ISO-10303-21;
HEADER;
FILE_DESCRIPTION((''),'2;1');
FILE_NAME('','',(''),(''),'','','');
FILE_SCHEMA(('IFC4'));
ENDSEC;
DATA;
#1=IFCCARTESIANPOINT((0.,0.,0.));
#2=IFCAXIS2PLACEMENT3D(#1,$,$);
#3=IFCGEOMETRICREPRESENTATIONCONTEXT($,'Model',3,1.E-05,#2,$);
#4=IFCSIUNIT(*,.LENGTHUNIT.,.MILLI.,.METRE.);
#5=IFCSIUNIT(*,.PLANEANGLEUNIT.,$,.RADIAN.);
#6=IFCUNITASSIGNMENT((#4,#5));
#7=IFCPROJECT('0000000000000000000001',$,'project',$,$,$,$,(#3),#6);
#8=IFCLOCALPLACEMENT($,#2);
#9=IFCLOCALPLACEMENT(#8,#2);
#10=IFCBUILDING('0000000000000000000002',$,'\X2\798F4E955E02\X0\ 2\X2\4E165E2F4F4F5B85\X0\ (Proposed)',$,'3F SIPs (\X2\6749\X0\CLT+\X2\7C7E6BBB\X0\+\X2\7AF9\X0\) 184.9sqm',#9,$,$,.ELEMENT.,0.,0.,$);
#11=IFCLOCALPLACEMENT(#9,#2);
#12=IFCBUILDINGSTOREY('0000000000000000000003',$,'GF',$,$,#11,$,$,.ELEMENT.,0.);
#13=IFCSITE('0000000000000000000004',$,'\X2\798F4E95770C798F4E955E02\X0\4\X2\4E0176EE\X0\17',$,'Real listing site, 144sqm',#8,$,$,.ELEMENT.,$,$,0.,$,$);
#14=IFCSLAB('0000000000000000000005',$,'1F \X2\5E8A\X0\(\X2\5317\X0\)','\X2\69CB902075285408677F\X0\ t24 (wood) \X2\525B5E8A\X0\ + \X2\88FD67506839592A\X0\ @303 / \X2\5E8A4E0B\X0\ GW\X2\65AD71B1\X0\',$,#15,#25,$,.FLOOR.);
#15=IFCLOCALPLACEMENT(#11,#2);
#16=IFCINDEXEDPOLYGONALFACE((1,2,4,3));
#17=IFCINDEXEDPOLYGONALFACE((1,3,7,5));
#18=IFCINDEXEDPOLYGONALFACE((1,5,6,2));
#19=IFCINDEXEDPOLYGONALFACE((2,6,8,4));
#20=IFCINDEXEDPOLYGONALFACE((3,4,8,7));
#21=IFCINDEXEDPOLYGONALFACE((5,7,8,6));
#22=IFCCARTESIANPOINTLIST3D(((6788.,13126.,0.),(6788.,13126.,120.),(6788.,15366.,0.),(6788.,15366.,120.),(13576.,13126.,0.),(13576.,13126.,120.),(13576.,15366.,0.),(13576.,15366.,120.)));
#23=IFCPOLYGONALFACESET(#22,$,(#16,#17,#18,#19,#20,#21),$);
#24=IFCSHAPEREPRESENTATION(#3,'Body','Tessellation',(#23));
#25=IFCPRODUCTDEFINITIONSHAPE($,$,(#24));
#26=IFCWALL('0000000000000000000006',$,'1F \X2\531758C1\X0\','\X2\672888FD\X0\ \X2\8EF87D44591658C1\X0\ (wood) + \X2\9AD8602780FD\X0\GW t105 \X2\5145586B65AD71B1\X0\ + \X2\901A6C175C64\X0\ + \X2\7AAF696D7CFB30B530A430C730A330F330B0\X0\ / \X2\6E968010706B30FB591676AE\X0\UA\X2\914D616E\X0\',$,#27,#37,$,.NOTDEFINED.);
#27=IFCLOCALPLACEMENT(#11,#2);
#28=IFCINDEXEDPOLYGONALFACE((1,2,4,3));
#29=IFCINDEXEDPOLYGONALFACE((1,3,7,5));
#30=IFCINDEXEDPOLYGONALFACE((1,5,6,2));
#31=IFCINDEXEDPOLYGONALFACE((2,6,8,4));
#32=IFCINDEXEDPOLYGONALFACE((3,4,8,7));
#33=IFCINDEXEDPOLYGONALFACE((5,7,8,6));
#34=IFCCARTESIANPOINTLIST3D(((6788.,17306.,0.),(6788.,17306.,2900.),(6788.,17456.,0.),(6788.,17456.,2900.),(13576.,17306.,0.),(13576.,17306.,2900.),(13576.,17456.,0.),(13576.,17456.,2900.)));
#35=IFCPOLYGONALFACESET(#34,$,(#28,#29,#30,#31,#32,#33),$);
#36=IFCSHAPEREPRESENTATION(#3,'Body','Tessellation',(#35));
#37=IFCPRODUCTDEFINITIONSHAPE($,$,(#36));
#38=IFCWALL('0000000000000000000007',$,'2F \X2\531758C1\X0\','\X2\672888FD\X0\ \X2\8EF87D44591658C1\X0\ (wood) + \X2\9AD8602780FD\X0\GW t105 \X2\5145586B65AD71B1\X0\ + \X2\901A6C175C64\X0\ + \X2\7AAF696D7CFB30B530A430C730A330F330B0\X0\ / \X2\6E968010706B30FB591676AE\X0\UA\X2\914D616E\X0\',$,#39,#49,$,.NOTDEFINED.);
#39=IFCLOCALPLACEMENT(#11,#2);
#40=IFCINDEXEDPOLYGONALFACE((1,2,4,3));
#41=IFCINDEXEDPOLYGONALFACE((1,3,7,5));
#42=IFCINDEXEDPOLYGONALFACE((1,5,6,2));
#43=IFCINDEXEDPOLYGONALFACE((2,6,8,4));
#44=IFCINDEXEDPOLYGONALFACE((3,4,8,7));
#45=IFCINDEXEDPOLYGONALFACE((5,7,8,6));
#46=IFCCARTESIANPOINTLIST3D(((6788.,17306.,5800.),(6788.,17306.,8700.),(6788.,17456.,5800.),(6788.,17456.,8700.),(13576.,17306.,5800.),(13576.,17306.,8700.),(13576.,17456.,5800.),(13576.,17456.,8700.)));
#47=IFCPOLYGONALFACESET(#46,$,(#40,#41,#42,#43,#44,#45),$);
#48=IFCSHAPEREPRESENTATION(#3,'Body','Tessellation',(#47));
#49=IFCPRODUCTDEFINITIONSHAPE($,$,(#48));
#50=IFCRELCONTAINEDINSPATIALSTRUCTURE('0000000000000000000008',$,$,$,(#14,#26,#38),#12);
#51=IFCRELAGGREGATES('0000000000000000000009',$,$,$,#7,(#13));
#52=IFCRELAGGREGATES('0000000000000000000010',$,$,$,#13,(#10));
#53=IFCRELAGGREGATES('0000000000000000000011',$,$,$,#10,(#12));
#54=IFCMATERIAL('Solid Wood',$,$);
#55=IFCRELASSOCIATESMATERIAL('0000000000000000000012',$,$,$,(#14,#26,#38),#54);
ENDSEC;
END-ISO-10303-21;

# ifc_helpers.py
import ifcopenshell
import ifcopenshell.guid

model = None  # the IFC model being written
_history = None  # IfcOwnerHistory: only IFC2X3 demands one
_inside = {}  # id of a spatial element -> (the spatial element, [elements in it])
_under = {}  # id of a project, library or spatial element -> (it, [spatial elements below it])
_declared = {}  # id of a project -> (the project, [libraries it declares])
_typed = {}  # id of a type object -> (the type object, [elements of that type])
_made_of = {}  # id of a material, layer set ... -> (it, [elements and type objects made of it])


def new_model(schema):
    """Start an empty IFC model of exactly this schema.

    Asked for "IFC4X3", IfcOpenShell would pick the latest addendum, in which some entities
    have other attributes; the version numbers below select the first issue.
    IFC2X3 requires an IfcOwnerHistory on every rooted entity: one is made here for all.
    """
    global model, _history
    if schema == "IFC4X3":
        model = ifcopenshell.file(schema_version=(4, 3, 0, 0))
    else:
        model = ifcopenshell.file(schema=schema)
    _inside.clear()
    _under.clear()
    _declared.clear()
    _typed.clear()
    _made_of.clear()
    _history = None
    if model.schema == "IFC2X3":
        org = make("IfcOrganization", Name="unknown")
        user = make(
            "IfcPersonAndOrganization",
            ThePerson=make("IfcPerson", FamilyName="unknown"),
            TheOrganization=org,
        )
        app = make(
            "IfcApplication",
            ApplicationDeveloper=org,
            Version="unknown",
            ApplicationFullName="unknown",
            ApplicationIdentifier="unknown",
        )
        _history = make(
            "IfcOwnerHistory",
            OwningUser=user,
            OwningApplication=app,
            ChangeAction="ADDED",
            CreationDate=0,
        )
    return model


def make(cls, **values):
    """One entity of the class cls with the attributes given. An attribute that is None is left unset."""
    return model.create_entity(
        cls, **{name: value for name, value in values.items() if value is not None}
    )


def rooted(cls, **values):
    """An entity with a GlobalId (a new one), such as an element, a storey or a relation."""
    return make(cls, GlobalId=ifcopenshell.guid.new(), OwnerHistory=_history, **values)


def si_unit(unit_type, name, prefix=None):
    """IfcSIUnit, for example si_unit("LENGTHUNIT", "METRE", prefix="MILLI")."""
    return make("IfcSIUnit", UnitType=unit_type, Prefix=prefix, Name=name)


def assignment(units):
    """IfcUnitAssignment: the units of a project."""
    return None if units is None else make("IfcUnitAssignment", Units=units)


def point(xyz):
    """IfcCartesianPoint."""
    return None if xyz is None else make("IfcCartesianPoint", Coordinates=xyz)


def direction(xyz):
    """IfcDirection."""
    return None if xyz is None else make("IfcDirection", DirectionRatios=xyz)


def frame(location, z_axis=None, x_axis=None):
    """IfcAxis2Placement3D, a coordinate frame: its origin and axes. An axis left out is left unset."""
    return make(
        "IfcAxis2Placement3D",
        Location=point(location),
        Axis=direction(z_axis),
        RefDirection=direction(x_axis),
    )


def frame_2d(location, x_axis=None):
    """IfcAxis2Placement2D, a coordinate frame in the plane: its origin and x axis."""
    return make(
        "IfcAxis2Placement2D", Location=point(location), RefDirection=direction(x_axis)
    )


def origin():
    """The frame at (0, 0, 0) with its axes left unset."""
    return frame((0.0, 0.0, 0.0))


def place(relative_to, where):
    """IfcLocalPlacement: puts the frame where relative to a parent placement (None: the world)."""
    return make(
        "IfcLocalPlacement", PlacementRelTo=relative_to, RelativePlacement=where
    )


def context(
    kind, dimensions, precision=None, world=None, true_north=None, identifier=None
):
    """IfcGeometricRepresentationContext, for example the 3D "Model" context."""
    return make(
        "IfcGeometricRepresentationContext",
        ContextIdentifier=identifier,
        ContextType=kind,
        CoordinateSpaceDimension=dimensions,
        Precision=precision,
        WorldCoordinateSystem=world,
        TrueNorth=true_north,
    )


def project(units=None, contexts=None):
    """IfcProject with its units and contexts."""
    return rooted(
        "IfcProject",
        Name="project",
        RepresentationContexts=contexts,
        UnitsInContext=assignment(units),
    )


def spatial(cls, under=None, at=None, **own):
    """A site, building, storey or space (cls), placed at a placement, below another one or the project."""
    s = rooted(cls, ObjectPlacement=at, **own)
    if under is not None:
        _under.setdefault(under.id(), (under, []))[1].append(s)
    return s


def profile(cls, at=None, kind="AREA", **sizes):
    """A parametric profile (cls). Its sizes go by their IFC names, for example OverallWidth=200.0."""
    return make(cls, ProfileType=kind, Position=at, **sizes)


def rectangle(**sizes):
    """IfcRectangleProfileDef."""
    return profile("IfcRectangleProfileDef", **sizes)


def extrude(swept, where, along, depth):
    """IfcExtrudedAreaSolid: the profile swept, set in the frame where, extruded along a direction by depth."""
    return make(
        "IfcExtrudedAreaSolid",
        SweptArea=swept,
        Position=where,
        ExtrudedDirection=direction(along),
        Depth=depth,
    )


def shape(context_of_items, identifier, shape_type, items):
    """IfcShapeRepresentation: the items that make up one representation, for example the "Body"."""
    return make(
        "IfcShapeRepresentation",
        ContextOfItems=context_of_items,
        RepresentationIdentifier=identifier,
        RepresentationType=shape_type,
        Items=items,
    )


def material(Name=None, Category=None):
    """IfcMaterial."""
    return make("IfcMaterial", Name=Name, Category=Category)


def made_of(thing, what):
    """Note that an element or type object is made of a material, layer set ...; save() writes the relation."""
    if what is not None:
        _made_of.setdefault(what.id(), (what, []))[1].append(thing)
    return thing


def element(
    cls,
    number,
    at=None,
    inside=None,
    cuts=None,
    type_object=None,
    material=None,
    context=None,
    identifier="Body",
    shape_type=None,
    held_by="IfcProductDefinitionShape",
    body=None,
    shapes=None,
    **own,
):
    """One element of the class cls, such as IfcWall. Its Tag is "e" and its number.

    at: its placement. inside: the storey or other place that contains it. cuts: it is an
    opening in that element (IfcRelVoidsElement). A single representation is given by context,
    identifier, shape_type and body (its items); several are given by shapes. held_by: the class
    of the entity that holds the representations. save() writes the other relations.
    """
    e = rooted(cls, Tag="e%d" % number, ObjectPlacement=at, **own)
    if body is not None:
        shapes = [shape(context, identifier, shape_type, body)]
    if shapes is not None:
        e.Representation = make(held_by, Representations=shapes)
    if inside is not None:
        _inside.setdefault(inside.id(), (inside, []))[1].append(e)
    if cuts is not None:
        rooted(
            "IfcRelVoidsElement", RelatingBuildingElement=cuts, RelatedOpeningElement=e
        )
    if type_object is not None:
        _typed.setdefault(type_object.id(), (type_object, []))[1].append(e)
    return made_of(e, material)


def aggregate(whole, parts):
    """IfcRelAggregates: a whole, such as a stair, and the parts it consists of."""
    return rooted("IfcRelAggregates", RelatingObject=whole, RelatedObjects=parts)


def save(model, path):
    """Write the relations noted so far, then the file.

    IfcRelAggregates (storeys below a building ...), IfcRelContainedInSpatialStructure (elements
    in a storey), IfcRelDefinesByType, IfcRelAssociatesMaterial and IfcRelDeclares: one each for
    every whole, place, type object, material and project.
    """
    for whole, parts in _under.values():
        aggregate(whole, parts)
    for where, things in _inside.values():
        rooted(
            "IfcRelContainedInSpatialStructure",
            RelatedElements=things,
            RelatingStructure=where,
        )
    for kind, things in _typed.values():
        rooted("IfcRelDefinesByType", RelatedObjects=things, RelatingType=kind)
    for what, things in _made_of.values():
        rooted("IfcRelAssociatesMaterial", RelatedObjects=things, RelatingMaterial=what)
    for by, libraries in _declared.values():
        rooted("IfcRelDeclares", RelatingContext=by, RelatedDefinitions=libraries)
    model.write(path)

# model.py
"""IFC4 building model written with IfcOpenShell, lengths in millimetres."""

from ifc_helpers import new_model, si_unit, frame, frame_2d, origin, place, context, project, spatial, rectangle, extrude, material, element, save


model = new_model("IFC4")

# Units and contexts
model_context = context("Model", 3, precision=1e-05, world=origin())
ifc_project = project(units=[si_unit("LENGTHUNIT", "METRE", prefix="MILLI"), si_unit("PLANEANGLEUNIT", "RADIAN")], contexts=[model_context])

# Site, building, storey
site_placement = place(None, origin())
site = spatial("IfcSite", under=ifc_project, at=site_placement, Name="福井県福井市4丁目17", ObjectType="Real listing site, 144sqm", CompositionType="ELEMENT", RefElevation=0.0)
building_placement = place(site_placement, origin())
building = spatial("IfcBuilding", under=site, at=building_placement, Name="福井市 2世帯住宅 (Proposed)", ObjectType="3F SIPs (杉CLT+籾殻+竹) 184.9sqm", CompositionType="ELEMENT", ElevationOfRefHeight=0.0, ElevationOfTerrain=0.0)
storey_placement = place(building_placement, origin())
storey = spatial("IfcBuildingStorey", under=building, at=storey_placement, Name="GF", CompositionType="ELEMENT", Elevation=0.0)

# Slab
ifc_material_1 = material(Name="Solid Wood")
slab_1_placement = place(storey_placement, frame((3394.0, 6563.0, 0.0)))
element("IfcSlab", 1, at=slab_1_placement, inside=storey, material=ifc_material_1, Name="1F 床(北)", Description="構造用合板 t24 (wood) 剛床 + 製材根太 @303 / 床下 GW断熱", PredefinedType="FLOOR", context=model_context, shape_type="SweptSolid", body=[
    extrude(rectangle(XDim=6788.0, YDim=2240.0, at=frame_2d((3394.0, 1120.0))), frame((3394.0, 6563.0, 0.0)), (0.0, 0.0, 1.0), 120.0),
])

# Wall
wall_1_placement = place(storey_placement, frame((3394.0, 8653.0, 0.0)))
element("IfcWall", 2, at=wall_1_placement, inside=storey, material=ifc_material_1, Name="1F 北壁", Description="木製 軸組外壁 (wood) + 高性能GW t105 充填断熱 + 通気層 + 窯業系サイディング / 準耐火・外皮UA配慮", PredefinedType="NOTDEFINED", context=model_context, shape_type="SweptSolid", body=[
    extrude(rectangle(XDim=6788.0, YDim=150.0, at=frame_2d((3394.0, 75.0))), frame((3394.0, 8653.0, 0.0)), (0.0, 0.0, 1.0), 2900.0),
])

# Wall
wall_2_placement = place(storey_placement, frame((3394.0, 8653.0, 2900.0)))
element("IfcWall", 3, at=wall_2_placement, inside=storey, material=ifc_material_1, Name="2F 北壁", Description="木製 軸組外壁 (wood) + 高性能GW t105 充填断熱 + 通気層 + 窯業系サイディング / 準耐火・外皮UA配慮", PredefinedType="NOTDEFINED", context=model_context, shape_type="SweptSolid", body=[
    extrude(rectangle(XDim=6788.0, YDim=150.0, at=frame_2d((3394.0, 75.0))), frame((3394.0, 8653.0, 2900.0)), (0.0, 0.0, 1.0), 2900.0),
])

save(model, "model.ifc")
